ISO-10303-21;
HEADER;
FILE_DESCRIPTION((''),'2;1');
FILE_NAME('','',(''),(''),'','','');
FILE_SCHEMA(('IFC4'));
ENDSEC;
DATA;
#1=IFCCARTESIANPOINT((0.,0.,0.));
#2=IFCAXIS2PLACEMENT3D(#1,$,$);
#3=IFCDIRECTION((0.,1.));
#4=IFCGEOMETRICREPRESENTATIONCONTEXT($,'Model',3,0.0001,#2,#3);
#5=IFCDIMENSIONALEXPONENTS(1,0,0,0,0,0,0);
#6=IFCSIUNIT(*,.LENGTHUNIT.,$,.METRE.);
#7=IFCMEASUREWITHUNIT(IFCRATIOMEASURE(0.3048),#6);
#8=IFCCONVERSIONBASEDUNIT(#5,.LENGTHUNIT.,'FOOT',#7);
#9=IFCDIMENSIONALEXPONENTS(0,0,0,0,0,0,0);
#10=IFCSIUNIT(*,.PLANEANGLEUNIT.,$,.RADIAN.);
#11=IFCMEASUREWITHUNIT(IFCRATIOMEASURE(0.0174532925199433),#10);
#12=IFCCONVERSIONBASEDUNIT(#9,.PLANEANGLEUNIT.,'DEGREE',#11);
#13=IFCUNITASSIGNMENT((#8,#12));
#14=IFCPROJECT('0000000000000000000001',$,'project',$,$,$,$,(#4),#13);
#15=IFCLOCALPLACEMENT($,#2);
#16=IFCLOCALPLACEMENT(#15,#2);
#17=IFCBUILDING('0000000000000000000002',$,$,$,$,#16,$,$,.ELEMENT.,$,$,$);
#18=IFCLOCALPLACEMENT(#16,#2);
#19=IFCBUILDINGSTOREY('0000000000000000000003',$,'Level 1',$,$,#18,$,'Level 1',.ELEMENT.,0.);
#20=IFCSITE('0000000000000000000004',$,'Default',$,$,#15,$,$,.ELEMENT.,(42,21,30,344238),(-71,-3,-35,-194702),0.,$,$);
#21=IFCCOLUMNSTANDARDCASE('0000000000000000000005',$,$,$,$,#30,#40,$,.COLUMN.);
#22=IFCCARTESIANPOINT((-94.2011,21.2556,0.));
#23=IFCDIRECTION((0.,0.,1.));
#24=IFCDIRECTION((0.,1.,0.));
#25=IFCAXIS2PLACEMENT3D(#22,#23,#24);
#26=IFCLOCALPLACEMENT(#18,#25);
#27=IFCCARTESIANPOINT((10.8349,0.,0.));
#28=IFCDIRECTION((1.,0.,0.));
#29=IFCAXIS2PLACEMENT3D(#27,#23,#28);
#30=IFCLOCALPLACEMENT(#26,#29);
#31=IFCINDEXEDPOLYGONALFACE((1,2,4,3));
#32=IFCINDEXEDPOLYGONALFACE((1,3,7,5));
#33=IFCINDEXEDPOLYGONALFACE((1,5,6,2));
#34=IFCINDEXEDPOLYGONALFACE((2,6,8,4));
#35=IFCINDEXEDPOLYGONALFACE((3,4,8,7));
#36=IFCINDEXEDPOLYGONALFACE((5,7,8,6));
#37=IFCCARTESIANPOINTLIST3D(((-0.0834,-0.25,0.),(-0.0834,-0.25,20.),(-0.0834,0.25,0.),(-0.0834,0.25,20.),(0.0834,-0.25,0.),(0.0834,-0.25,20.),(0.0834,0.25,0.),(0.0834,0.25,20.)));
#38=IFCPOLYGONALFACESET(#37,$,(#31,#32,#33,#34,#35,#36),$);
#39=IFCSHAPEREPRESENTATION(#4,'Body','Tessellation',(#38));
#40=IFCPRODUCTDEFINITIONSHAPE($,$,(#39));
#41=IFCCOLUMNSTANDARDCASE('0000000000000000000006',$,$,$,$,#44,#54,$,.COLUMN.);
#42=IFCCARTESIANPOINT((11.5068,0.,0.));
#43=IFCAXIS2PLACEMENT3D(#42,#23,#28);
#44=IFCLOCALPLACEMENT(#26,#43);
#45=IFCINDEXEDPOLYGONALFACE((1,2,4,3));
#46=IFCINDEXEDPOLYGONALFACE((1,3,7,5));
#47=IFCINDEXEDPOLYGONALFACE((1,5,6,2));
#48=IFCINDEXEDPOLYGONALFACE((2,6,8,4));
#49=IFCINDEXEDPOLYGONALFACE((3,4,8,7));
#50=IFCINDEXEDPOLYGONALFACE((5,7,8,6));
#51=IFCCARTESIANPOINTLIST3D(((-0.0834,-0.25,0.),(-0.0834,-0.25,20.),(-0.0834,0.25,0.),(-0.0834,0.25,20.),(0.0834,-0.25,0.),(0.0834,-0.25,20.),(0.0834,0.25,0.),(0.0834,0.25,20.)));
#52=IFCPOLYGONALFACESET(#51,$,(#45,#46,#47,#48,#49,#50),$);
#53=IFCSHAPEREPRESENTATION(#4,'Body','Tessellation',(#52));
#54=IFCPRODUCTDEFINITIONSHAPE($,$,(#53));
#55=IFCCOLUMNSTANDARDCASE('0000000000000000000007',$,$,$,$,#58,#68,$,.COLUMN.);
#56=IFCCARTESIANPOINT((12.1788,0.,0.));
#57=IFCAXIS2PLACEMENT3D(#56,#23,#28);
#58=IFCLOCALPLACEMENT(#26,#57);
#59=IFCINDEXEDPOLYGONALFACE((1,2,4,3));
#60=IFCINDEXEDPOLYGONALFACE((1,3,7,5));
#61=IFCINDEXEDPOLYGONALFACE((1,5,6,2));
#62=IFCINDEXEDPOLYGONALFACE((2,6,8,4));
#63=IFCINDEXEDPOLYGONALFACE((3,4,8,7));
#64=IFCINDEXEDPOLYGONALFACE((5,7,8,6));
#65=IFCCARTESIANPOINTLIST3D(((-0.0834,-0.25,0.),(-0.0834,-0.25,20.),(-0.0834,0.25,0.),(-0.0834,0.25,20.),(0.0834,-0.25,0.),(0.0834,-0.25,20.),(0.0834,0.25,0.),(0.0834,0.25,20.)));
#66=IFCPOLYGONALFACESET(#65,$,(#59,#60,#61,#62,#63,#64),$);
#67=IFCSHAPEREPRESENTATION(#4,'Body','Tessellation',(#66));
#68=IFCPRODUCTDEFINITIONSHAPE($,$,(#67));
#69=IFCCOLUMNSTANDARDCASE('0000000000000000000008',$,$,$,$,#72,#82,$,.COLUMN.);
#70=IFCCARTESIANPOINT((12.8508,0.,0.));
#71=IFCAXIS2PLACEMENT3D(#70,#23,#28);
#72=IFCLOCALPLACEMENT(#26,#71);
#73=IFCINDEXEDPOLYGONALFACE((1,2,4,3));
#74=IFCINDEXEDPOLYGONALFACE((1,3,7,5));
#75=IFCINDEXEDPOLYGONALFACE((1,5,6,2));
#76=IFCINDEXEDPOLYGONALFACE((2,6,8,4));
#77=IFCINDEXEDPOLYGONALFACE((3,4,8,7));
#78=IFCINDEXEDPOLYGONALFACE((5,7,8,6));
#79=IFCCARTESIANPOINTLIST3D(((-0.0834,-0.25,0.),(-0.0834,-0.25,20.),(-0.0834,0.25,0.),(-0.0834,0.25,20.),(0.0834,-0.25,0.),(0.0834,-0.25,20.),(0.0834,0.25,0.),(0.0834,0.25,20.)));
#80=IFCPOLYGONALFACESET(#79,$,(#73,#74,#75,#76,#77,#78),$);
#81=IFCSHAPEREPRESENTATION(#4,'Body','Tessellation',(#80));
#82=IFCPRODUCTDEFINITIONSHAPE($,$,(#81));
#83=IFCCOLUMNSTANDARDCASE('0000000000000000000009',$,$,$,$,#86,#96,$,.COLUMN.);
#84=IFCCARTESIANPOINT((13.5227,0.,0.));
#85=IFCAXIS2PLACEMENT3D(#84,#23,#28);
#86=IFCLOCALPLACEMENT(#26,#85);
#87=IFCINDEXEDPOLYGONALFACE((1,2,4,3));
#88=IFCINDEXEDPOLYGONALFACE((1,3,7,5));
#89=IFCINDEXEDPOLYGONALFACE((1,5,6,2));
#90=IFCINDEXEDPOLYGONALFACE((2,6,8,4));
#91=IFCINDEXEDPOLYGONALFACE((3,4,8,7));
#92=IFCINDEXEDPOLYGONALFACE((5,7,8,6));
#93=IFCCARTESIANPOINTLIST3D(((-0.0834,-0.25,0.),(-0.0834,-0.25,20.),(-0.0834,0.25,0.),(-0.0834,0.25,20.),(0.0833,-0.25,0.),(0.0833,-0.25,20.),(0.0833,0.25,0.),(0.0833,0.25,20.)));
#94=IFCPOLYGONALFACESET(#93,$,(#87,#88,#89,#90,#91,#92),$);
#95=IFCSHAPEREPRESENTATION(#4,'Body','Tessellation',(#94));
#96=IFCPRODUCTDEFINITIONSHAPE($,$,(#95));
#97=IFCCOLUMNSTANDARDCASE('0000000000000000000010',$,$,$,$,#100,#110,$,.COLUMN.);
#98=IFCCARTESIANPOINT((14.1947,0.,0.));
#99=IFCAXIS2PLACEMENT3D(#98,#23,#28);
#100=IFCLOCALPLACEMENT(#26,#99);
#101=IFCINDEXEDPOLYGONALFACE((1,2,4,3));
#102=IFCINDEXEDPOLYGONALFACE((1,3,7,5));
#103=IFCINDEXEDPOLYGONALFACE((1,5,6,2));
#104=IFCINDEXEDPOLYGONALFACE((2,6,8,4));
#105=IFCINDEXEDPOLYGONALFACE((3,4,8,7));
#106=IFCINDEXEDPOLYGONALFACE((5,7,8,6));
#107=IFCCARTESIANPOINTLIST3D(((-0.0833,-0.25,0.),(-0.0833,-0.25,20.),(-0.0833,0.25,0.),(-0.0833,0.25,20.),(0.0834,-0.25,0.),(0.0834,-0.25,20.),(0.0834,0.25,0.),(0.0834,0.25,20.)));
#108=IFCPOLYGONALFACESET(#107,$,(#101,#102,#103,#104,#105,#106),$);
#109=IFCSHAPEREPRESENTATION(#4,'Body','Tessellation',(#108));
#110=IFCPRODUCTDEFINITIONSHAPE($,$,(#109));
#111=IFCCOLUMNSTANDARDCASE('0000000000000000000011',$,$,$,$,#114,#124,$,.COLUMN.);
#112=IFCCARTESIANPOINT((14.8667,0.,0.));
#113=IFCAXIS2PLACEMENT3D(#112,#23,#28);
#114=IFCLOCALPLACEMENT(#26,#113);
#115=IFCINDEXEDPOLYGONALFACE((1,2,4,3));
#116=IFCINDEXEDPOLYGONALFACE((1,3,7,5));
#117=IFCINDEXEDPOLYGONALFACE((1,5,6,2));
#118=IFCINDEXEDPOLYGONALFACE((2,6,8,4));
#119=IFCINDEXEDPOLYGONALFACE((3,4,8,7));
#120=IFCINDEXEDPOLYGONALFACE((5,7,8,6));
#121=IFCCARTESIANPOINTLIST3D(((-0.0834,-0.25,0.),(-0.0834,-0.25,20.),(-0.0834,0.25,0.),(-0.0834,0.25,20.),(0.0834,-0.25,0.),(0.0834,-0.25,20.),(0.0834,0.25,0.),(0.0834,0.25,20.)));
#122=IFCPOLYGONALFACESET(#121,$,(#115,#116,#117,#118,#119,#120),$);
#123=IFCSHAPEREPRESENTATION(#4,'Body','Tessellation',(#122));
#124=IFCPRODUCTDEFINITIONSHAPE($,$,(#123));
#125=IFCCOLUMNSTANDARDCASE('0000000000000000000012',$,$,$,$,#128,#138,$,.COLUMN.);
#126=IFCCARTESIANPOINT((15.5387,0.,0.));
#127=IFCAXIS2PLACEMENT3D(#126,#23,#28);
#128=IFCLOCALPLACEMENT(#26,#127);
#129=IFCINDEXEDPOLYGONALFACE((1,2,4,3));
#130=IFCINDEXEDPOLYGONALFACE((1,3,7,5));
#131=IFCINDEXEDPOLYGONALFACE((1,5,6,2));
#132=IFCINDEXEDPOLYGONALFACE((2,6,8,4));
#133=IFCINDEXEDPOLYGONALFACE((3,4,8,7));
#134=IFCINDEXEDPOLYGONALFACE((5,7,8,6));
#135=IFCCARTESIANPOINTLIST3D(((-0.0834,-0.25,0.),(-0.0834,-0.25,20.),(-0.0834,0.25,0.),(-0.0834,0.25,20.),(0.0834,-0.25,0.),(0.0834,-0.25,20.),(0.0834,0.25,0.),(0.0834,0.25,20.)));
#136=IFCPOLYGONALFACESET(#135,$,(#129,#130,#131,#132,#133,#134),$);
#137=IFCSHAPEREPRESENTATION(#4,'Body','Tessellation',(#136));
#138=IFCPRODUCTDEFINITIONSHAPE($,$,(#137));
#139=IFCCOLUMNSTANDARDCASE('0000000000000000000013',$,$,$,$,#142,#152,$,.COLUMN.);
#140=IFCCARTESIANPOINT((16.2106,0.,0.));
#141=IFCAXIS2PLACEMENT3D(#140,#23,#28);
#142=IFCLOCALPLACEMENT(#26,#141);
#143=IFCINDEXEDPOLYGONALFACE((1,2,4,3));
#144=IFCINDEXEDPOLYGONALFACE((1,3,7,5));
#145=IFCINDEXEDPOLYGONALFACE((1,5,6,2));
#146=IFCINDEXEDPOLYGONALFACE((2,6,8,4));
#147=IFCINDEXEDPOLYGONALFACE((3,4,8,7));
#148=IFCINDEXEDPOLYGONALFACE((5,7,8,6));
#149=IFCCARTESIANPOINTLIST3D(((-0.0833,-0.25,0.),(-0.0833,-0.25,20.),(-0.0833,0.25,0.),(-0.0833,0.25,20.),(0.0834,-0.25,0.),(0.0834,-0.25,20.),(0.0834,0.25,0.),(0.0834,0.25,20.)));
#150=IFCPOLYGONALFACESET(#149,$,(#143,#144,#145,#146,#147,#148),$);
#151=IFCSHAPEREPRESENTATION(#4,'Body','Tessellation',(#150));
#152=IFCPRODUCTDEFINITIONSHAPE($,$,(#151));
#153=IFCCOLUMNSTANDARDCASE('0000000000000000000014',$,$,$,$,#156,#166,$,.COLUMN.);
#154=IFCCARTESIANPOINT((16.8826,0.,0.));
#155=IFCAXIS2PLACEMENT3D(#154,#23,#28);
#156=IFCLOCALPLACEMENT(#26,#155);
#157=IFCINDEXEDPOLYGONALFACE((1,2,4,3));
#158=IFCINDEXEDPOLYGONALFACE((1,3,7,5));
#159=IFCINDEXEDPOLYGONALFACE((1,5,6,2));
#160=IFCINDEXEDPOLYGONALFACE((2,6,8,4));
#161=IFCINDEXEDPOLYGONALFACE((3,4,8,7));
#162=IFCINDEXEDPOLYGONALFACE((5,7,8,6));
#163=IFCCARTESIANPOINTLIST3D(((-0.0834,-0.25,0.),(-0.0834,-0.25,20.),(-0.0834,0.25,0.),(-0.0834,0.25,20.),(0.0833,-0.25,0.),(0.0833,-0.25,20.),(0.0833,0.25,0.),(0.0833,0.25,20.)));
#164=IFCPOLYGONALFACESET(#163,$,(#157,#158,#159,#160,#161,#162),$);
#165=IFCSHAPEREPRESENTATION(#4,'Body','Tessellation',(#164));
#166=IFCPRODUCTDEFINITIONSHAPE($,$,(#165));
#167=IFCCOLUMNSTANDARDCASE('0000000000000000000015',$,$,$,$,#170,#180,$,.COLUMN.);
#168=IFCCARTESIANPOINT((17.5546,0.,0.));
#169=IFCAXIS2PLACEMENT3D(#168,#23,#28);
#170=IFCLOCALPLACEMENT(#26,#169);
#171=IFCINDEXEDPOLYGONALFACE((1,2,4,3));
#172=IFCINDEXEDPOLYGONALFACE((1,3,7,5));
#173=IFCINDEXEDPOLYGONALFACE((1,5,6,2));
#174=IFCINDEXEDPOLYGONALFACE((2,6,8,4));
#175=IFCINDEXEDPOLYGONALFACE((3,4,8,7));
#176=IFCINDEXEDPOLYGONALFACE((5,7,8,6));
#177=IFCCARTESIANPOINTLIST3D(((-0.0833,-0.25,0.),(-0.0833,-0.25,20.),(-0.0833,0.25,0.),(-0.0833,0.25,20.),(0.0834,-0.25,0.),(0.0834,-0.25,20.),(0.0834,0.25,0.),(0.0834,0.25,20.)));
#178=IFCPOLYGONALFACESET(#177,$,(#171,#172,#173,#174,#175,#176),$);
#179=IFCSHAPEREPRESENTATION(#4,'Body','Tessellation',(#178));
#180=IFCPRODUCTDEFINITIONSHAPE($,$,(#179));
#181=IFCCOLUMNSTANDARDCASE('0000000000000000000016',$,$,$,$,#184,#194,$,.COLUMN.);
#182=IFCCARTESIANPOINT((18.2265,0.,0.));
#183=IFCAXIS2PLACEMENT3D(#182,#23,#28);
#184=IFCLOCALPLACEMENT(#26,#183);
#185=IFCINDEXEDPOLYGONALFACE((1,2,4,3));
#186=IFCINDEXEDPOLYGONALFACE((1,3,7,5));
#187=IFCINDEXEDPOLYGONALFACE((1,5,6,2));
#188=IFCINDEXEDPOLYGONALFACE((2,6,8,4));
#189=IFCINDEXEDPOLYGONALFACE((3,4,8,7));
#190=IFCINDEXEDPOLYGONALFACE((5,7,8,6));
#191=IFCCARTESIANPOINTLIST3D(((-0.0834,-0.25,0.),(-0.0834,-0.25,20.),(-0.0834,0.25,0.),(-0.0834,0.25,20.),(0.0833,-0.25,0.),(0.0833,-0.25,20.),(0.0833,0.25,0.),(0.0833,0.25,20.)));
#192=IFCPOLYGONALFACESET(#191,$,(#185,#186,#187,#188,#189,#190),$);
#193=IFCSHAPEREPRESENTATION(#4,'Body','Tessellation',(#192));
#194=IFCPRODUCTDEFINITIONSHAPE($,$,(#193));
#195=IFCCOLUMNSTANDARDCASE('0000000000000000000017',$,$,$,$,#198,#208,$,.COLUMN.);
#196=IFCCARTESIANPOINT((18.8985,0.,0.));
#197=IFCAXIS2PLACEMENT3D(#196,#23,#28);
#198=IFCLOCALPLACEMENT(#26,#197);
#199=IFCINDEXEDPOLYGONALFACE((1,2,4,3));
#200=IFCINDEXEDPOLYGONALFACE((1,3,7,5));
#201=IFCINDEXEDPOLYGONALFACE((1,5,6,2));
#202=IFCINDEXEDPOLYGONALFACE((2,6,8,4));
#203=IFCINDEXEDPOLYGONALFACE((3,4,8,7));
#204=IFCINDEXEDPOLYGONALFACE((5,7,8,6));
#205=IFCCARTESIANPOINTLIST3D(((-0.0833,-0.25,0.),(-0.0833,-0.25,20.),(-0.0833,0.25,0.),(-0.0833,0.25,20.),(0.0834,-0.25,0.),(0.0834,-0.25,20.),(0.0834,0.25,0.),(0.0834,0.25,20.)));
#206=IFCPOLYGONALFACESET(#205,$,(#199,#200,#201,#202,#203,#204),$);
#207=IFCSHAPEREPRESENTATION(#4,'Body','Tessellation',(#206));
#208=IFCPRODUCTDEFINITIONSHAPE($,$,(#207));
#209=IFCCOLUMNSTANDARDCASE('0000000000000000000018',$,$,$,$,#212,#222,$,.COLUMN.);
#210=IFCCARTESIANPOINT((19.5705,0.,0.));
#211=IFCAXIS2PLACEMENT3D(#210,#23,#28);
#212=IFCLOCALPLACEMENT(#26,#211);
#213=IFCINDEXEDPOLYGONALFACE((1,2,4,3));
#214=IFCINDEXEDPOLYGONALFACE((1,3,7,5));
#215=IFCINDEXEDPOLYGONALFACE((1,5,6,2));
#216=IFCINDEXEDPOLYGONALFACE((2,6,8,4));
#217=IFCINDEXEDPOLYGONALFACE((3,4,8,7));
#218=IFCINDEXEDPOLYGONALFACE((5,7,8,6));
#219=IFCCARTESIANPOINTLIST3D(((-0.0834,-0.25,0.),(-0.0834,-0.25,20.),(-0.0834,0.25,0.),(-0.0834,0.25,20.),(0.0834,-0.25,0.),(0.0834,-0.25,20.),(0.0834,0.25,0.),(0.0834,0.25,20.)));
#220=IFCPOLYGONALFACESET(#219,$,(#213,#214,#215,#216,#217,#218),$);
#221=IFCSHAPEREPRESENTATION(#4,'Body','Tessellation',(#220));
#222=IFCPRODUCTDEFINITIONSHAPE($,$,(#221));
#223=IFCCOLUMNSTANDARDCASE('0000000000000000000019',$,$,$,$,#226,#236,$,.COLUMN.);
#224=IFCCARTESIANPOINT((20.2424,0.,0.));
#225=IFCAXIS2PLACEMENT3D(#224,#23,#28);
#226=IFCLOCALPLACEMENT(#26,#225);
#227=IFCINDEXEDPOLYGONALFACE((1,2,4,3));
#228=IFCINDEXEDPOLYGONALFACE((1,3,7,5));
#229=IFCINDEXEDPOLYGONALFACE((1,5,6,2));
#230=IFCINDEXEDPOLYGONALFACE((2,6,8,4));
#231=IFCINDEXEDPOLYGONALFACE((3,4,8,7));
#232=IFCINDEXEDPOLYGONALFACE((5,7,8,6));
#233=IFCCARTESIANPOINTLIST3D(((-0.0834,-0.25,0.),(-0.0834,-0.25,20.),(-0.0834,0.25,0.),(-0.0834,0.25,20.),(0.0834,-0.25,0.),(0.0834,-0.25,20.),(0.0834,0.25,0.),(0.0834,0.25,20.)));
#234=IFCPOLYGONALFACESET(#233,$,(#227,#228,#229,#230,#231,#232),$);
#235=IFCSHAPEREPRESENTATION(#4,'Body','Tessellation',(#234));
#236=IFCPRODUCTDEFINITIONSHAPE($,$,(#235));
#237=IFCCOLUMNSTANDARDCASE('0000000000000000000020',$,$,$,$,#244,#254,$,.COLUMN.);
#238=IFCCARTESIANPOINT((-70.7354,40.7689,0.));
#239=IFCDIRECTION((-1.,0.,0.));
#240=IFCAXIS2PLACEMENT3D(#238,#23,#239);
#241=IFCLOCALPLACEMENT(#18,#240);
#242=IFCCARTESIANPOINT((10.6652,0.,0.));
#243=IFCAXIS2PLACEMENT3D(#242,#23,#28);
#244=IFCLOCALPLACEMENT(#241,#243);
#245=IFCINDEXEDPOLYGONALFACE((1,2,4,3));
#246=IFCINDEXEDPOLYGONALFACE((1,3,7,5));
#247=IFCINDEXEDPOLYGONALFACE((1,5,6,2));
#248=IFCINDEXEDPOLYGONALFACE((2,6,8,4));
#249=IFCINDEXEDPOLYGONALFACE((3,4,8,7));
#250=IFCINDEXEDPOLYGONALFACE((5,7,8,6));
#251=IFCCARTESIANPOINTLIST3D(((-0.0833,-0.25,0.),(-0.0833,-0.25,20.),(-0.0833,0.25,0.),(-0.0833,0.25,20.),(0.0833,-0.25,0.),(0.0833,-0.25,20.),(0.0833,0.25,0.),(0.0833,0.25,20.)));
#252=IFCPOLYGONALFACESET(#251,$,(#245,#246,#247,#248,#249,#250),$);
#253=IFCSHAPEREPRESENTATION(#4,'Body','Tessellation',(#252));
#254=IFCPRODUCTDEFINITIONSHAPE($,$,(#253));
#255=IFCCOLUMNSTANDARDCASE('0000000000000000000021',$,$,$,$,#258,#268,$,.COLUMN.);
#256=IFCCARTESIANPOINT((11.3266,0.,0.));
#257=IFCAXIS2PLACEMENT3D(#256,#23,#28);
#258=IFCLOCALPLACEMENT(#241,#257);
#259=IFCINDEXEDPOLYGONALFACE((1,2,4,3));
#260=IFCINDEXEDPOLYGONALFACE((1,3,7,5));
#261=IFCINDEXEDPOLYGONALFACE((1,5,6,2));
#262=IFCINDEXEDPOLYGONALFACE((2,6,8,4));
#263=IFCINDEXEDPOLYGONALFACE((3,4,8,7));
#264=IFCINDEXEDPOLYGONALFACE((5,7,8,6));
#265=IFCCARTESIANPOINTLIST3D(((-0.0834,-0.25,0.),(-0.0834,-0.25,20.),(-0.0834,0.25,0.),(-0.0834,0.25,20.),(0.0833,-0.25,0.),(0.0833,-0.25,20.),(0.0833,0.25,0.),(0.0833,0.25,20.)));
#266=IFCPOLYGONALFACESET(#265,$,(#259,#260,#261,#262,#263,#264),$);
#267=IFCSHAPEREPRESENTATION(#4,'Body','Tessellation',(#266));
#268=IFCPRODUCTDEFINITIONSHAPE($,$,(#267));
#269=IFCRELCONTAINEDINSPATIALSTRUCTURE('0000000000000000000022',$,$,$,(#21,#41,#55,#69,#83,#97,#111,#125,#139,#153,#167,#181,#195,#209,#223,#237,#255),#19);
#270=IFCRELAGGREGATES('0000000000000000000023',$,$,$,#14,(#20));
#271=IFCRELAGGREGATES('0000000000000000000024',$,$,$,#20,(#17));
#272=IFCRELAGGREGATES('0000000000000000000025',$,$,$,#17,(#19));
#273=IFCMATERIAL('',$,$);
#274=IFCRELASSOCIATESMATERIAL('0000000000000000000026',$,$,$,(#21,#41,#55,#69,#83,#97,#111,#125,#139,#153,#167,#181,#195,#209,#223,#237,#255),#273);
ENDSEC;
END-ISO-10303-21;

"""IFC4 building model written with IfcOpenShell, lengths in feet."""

from ifc_helpers import new_model, entity, si_unit, converted_unit, direction, frame, origin, place, context, project, spatial, rectangle, extrude, material, element, save


model = new_model("IFC4")

# Units and contexts
model_context = context("Model", 3, precision=0.0001, world=origin(), true_north=direction((0.0, 1.0)))
ifc_project = project(units=[converted_unit("LENGTHUNIT", "FOOT", entity("IfcRatioMeasure", 0.3048), si_unit("LENGTHUNIT", "METRE"), dimensions=[1, 0, 0, 0, 0, 0, 0]), converted_unit("PLANEANGLEUNIT", "DEGREE", entity("IfcRatioMeasure", 0.0174532925199433), si_unit("PLANEANGLEUNIT", "RADIAN"), dimensions=[0, 0, 0, 0, 0, 0, 0])], contexts=[model_context])

# Site, building, storey
site_placement = place(None, origin())
site = spatial("IfcSite", under=ifc_project, at=site_placement, Name="Default", CompositionType="ELEMENT", RefLatitude=(42, 21, 30, 344238), RefLongitude=(-71, -3, -35, -194702), RefElevation=0.0)
building_placement = place(site_placement, origin())
building = spatial("IfcBuilding", under=site, at=building_placement, CompositionType="ELEMENT")
storey_placement = place(building_placement, origin())
storey = spatial("IfcBuildingStorey", under=building, at=storey_placement, Name="Level 1", LongName="Level 1", CompositionType="ELEMENT", Elevation=0.0)

# Columns
ifc_material_1 = material(Name="")
placement_1 = place(storey_placement, frame((-94.2011, 21.2556, 0.0), z_axis=(0.0, 0.0, 1.0), x_axis=(0.0, 1.0, 0.0)))
for number, where, z_axis, x_axis in (
    (1, (10.8349, 0.0, 0.0), (0.0, 0.0, 1.0), (1.0, 0.0, 0.0)),
    (2, (11.5068, 0.0, 0.0), (0.0, 0.0, 1.0), (1.0, 0.0, 0.0)),
    (3, (12.1788, 0.0, 0.0), (0.0, 0.0, 1.0), (1.0, 0.0, 0.0)),
    (4, (12.8508, 0.0, 0.0), (0.0, 0.0, 1.0), (1.0, 0.0, 0.0)),
    (5, (13.5227, 0.0, 0.0), (0.0, 0.0, 1.0), (1.0, 0.0, 0.0)),
    (6, (14.1947, 0.0, 0.0), (0.0, 0.0, 1.0), (1.0, 0.0, 0.0)),
    (7, (14.8667, 0.0, 0.0), (0.0, 0.0, 1.0), (1.0, 0.0, 0.0)),
    (8, (15.5387, 0.0, 0.0), (0.0, 0.0, 1.0), (1.0, 0.0, 0.0)),
    (9, (16.2106, 0.0, 0.0), (0.0, 0.0, 1.0), (1.0, 0.0, 0.0)),
    (10, (16.8826, 0.0, 0.0), (0.0, 0.0, 1.0), (1.0, 0.0, 0.0)),
    (11, (17.5546, 0.0, 0.0), (0.0, 0.0, 1.0), (1.0, 0.0, 0.0)),
    (12, (18.2265, 0.0, 0.0), (0.0, 0.0, 1.0), (1.0, 0.0, 0.0)),
    (13, (18.8985, 0.0, 0.0), (0.0, 0.0, 1.0), (1.0, 0.0, 0.0)),
    (14, (19.5705, 0.0, 0.0), (0.0, 0.0, 1.0), (1.0, 0.0, 0.0)),
    (15, (20.2424, 0.0, 0.0), (0.0, 0.0, 1.0), (1.0, 0.0, 0.0)),
):
    element("IfcColumnStandardCase", number, at=place(placement_1, frame(where, z_axis=z_axis, x_axis=x_axis)), inside=storey, material=ifc_material_1, PredefinedType="COLUMN", context=model_context, shape_type="SweptSolid", body=[
        extrude(rectangle(XDim=0.1667, YDim=0.5), origin(), (0.0, 0.0, 1.0), 20.0),
    ])
placement_2 = place(storey_placement, frame((-70.7354, 40.7689, 0.0), z_axis=(0.0, 0.0, 1.0), x_axis=(-1.0, 0.0, 0.0)))
for number, where, z_axis, x_axis in (
    (16, (10.6652, 0.0, 0.0), (0.0, 0.0, 1.0), (1.0, 0.0, 0.0)),
    (17, (11.3266, 0.0, 0.0), (0.0, 0.0, 1.0), (1.0, 0.0, 0.0)),
):
    element("IfcColumnStandardCase", number, at=place(placement_2, frame(where, z_axis=z_axis, x_axis=x_axis)), inside=storey, material=ifc_material_1, PredefinedType="COLUMN", context=model_context, shape_type="SweptSolid", body=[
        extrude(rectangle(XDim=0.1667, YDim=0.5), origin(), (0.0, 0.0, 1.0), 20.0),
    ])

save(model, "model.ifc")
